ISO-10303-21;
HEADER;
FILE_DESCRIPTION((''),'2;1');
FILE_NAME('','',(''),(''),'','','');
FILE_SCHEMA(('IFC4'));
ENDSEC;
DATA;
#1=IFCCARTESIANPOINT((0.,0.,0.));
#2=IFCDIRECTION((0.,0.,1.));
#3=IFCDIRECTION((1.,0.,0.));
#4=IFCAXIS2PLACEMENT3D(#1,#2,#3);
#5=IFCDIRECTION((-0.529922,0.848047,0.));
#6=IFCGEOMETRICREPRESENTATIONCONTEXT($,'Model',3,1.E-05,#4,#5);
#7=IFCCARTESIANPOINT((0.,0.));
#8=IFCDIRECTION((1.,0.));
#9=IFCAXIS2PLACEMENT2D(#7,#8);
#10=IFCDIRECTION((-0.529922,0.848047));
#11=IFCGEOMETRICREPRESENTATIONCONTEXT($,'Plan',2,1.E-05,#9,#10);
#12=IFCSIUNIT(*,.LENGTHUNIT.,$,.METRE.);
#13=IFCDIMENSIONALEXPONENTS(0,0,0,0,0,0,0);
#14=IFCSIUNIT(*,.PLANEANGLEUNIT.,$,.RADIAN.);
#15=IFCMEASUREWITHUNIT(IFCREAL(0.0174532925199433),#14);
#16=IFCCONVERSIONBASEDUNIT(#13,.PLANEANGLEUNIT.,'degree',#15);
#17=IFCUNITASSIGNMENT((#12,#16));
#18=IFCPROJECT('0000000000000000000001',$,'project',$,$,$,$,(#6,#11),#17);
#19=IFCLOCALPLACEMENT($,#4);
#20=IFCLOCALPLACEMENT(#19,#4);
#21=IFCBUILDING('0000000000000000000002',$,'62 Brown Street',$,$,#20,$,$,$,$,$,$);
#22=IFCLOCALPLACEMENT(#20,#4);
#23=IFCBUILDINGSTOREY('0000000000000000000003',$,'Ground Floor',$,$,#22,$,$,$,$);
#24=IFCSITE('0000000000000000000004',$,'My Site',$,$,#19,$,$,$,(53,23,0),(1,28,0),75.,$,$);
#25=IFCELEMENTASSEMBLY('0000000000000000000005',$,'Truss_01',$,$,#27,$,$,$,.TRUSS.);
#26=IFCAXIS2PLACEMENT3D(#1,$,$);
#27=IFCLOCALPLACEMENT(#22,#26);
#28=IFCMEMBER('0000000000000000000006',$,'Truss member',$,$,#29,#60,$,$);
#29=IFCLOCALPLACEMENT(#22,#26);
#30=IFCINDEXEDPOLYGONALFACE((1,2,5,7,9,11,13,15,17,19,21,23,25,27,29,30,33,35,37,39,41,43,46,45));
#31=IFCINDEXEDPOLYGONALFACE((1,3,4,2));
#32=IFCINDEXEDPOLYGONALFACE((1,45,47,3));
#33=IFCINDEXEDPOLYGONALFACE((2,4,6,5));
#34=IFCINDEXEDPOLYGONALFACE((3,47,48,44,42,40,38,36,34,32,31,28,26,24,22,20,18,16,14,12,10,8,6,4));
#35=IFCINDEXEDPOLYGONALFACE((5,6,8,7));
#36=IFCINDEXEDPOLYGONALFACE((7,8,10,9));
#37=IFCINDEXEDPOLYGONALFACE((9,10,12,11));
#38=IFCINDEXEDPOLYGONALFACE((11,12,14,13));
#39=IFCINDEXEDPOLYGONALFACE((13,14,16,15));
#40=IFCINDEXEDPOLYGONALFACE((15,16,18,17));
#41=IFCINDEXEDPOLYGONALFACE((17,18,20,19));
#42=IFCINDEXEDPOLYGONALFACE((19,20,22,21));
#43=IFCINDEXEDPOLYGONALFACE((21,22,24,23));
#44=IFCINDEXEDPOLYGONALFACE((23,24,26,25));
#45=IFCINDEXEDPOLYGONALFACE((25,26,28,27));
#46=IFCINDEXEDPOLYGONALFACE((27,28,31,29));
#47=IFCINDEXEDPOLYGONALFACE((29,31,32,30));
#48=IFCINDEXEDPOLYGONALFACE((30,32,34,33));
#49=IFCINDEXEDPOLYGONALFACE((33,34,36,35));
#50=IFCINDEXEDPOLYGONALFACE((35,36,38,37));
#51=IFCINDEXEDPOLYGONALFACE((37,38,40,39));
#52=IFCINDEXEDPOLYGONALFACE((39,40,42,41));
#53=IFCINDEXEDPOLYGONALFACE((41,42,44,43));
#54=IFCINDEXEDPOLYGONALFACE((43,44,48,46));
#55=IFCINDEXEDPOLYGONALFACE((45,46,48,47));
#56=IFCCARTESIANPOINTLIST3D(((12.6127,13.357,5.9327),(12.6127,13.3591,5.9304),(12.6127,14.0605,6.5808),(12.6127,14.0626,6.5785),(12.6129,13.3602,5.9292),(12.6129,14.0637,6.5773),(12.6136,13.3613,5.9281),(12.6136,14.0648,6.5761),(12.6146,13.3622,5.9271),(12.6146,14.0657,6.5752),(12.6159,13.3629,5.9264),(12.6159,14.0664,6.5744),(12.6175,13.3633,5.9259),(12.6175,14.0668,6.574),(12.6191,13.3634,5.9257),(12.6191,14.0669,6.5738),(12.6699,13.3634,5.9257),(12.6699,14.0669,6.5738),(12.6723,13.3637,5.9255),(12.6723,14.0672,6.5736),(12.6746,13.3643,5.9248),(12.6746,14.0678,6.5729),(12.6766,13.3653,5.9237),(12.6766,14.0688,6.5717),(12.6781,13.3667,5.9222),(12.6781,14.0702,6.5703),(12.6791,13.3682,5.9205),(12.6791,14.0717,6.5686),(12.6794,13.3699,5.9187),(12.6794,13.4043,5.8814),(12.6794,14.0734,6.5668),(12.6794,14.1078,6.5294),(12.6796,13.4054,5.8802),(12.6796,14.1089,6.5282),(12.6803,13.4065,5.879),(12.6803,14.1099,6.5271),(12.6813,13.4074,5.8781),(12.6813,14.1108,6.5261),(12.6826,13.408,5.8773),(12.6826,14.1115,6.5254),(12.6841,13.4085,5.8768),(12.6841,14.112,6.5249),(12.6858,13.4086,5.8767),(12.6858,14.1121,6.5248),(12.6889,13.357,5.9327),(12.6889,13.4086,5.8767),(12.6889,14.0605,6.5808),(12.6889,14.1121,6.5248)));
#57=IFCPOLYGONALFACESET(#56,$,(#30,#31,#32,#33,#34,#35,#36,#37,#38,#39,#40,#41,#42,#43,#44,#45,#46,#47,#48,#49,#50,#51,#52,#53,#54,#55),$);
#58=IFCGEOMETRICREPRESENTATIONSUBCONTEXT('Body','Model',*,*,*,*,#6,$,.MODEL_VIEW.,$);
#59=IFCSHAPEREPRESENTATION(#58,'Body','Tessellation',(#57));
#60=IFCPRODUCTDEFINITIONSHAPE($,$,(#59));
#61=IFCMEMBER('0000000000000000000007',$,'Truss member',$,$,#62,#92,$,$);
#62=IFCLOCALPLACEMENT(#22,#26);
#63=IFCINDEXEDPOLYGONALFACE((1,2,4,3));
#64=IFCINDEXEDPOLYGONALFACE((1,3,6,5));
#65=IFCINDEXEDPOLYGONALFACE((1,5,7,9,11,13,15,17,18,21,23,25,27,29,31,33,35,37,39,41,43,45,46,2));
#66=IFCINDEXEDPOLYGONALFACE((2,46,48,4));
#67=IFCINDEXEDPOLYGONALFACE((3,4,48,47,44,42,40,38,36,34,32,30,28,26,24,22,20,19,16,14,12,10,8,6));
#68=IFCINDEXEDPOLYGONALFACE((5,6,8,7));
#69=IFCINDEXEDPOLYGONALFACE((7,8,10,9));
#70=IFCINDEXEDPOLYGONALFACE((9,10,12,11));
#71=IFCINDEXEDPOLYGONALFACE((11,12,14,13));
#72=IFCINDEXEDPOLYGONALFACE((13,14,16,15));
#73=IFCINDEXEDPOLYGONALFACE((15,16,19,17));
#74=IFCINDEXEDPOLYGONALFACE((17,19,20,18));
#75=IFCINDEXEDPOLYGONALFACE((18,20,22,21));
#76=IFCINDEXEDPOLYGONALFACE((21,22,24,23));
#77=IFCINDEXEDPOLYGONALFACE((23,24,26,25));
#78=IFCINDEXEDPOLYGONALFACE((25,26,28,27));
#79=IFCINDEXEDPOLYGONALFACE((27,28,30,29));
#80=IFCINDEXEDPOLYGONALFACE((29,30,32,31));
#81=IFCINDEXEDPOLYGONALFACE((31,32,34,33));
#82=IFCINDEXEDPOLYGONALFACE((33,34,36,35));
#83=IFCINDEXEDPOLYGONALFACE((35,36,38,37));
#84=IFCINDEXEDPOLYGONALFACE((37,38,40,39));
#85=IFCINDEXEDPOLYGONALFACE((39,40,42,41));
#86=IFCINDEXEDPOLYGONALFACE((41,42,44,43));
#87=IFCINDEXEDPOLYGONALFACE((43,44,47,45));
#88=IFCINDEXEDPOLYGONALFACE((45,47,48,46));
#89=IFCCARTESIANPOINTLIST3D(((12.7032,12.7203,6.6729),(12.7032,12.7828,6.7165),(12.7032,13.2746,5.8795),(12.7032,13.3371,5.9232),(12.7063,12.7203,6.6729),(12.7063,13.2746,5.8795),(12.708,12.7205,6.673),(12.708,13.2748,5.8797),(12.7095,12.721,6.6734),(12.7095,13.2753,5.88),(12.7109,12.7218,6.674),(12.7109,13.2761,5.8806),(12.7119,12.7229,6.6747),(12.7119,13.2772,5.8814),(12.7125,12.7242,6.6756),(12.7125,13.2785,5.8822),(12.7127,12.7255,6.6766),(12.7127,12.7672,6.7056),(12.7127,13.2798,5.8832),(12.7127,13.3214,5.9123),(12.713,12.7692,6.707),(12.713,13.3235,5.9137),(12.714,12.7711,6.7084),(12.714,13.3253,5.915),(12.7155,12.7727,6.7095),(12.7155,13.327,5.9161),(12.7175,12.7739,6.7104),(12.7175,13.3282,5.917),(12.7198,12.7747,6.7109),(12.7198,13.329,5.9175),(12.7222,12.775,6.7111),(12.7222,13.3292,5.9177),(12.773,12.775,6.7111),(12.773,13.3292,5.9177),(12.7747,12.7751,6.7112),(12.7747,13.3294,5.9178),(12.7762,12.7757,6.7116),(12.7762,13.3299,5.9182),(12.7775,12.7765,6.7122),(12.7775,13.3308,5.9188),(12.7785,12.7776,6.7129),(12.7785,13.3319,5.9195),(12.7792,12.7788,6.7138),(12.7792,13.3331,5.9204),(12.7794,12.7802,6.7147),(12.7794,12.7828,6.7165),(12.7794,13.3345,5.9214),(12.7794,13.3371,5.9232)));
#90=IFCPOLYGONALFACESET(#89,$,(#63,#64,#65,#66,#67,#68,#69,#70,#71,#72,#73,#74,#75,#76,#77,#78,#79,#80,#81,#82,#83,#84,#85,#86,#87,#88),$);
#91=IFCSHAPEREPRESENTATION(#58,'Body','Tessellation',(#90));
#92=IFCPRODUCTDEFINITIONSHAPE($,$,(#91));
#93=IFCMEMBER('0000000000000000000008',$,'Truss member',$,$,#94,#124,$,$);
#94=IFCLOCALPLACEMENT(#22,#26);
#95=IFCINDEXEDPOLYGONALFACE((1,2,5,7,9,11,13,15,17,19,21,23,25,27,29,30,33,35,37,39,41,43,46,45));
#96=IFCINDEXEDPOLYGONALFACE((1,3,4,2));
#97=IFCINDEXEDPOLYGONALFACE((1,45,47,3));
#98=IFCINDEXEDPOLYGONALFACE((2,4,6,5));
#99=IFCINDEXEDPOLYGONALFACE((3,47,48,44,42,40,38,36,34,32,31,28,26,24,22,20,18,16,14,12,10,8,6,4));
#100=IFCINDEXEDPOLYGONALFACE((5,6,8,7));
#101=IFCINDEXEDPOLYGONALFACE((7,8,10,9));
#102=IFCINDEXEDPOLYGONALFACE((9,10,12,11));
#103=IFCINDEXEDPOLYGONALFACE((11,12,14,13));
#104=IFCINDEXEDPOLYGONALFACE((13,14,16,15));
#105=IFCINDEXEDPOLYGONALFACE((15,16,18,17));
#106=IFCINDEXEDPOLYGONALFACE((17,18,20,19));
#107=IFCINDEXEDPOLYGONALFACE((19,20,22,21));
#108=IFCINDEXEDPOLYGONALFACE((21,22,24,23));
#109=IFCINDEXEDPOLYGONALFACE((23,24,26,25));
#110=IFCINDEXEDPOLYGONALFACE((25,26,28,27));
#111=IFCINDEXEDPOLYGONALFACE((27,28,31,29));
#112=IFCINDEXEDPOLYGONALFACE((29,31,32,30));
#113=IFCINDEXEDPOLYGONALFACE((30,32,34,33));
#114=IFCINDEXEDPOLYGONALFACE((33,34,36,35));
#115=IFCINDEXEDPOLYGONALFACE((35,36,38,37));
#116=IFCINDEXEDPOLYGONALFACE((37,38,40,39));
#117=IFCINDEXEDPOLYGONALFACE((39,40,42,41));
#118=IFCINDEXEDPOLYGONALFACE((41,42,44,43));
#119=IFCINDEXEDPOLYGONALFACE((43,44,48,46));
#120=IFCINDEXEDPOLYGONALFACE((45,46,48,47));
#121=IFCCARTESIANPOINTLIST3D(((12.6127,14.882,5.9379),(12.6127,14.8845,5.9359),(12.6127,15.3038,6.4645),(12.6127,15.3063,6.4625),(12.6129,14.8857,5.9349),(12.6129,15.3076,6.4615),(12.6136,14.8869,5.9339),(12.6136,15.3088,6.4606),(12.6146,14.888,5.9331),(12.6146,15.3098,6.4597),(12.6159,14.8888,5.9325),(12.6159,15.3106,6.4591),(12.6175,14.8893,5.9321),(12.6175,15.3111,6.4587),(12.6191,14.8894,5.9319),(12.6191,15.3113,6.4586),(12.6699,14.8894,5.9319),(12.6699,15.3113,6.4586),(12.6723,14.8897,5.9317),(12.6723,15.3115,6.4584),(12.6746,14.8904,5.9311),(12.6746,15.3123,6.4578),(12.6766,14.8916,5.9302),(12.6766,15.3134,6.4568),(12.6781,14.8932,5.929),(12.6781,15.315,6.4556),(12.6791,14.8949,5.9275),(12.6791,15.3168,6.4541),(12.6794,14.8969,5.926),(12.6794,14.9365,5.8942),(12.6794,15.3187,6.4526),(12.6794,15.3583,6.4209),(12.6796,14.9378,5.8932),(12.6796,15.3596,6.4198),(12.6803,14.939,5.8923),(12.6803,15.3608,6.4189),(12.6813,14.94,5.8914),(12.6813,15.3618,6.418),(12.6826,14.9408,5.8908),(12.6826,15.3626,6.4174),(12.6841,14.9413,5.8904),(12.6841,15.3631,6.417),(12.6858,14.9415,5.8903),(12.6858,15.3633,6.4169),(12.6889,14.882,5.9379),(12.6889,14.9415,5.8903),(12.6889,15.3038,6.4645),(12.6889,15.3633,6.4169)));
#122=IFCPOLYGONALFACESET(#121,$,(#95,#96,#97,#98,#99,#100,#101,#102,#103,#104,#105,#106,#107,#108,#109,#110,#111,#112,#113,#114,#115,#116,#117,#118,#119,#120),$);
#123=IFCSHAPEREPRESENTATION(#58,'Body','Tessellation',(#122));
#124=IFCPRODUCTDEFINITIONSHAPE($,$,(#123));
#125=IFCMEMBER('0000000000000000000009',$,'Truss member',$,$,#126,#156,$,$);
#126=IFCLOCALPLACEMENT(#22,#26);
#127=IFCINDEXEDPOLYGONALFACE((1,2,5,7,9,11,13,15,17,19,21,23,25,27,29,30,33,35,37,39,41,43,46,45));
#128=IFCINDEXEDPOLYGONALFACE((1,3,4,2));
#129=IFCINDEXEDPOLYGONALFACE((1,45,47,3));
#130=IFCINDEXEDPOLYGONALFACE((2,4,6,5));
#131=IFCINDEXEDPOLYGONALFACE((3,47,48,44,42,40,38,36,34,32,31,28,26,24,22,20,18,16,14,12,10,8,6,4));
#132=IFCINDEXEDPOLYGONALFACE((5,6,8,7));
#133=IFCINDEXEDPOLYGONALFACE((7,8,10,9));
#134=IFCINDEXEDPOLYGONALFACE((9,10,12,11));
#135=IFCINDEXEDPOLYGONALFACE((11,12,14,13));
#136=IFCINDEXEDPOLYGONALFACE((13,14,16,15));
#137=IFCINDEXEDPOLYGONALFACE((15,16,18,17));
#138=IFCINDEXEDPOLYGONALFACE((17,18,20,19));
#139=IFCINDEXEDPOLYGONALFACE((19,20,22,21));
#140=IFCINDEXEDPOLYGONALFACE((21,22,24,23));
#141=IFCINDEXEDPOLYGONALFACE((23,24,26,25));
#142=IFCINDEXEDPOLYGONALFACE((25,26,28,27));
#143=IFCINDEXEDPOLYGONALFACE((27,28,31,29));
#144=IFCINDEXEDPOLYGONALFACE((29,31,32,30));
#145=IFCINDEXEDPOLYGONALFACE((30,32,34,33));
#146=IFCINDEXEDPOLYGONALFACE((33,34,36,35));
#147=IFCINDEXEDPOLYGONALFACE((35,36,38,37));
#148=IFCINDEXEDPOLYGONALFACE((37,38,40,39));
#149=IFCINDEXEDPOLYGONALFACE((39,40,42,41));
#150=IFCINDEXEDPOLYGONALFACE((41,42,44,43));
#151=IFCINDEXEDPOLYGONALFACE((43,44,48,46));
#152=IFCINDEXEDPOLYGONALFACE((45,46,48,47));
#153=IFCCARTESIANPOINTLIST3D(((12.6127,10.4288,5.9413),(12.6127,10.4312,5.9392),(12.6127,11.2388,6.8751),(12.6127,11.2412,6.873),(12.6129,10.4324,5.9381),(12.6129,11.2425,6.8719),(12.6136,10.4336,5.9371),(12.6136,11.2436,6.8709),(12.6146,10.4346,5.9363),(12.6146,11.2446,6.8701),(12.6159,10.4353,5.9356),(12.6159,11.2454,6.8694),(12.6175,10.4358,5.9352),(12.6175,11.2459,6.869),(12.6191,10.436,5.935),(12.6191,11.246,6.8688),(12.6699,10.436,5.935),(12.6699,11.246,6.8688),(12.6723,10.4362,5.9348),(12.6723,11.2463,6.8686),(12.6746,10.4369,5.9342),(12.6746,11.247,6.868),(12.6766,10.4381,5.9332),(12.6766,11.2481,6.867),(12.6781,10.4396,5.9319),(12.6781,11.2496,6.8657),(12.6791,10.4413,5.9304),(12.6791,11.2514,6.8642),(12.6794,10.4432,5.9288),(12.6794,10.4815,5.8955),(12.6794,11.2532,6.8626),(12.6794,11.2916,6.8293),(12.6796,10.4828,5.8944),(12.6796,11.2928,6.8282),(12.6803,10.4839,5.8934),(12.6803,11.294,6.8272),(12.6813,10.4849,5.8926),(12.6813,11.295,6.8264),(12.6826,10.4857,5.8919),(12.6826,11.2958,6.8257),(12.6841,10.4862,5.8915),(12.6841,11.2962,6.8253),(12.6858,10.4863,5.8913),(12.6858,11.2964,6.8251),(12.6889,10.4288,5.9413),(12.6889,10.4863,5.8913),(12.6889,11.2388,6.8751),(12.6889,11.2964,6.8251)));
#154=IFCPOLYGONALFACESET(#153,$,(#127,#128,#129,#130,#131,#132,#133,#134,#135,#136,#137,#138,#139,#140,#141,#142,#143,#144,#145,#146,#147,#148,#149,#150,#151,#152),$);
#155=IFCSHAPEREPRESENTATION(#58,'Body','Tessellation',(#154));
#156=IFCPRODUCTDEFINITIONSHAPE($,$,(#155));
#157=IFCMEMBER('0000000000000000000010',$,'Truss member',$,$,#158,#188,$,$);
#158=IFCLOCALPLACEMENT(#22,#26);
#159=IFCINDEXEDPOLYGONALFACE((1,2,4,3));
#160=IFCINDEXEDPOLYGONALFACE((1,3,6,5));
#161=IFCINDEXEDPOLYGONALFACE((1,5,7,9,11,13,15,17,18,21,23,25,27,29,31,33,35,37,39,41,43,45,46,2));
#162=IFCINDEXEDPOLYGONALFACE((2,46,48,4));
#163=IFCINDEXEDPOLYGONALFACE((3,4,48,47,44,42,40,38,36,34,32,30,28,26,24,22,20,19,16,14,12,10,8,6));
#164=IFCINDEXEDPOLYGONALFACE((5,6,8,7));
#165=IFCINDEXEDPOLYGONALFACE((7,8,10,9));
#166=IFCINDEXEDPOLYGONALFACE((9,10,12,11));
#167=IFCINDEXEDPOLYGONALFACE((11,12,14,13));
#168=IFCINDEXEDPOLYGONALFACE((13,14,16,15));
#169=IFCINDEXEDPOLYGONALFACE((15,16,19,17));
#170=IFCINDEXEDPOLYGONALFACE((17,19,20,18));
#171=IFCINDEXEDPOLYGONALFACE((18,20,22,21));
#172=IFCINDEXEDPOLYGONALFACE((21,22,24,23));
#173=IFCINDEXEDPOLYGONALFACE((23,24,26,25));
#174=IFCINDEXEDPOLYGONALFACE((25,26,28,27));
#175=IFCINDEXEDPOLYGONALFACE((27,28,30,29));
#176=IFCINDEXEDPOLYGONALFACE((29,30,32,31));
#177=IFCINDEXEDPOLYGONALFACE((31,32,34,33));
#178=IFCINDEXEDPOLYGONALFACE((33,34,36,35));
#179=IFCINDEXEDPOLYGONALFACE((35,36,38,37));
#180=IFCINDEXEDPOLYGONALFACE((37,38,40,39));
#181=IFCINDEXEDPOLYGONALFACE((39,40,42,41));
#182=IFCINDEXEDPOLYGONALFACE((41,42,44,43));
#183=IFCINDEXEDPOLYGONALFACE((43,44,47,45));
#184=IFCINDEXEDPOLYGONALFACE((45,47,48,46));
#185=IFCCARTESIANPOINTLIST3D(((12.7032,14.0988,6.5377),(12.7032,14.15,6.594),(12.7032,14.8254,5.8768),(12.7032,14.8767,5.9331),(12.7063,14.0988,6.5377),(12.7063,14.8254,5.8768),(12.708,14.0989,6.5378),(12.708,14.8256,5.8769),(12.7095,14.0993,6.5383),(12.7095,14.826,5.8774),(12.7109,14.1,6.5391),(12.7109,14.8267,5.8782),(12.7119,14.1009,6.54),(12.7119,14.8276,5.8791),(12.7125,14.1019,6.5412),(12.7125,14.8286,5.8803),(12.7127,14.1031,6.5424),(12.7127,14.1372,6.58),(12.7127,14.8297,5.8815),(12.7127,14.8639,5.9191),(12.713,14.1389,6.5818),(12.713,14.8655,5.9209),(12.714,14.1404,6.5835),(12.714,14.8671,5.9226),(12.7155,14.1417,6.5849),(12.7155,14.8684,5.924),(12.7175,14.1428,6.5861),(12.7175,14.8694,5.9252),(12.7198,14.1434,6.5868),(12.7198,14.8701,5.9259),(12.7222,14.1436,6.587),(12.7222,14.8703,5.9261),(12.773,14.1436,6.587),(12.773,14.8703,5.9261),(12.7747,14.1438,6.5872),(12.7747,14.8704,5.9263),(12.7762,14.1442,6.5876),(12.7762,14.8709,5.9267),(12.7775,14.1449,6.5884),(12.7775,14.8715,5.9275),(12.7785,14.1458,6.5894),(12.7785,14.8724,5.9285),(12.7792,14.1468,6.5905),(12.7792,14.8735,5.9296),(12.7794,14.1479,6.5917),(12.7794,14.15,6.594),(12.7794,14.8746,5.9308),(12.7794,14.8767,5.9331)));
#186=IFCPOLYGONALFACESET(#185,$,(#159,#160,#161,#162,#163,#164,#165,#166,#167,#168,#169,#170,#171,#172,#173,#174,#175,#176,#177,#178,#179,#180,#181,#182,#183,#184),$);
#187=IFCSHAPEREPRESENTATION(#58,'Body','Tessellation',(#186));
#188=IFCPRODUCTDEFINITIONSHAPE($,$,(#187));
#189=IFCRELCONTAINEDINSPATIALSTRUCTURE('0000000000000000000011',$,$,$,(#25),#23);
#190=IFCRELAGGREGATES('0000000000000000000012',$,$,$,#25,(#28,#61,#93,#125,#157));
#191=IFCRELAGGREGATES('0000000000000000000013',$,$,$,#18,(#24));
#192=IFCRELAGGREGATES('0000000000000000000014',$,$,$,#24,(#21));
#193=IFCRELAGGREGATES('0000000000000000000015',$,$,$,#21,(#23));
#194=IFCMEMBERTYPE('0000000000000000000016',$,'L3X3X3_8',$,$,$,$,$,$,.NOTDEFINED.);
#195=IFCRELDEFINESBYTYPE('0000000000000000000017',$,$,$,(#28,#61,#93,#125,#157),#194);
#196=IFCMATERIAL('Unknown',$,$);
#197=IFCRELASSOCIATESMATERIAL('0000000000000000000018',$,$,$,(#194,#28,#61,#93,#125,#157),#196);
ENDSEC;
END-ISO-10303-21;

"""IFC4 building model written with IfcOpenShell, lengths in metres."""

from ifc_helpers import new_model, entity, si_unit, converted_unit, direction, frame, origin_with_axes, origin_2d_with_axis, place, context, subcontext, project, spatial, l_section, extrude, material, material_profile, profile_set, profile_usage, type_object, element, aggregate, save


model = new_model("IFC4")

# Units and contexts
model_context = context("Model", 3, precision=1e-05, world=origin_with_axes(), true_north=direction((-0.529922, 0.848047, 0.0)))
plan_context = context("Plan", 2, precision=1e-05, world=origin_2d_with_axis(), true_north=direction((-0.529922, 0.848047)))
body_context = subcontext(model_context, "Body", "Model", "MODEL_VIEW")
ifc_project = project(units=[si_unit("LENGTHUNIT", "METRE"), converted_unit("PLANEANGLEUNIT", "degree", entity("IfcReal", 0.0174532925199433), si_unit("PLANEANGLEUNIT", "RADIAN"), dimensions=[0, 0, 0, 0, 0, 0, 0])], contexts=[model_context, plan_context])

# Site, building, storey
site_placement = place(None, origin_with_axes())
site = spatial("IfcSite", under=ifc_project, at=site_placement, Name="My Site", RefLatitude=(53, 23, 0), RefLongitude=(1, 28, 0), RefElevation=75.0)
building_placement = place(site_placement, origin_with_axes())
building = spatial("IfcBuilding", under=site, at=building_placement, Name="62 Brown Street")
storey_placement = place(building_placement, origin_with_axes())
storey = spatial("IfcBuildingStorey", under=building, at=storey_placement, Name="Ground Floor")

# Element assembly, members
ifc_material_1 = material(Name="Unknown")
ifc_material_profile_1 = material_profile(ifc_material_1, l_section(Depth=0.0762, Width=0.0762, Thickness=0.0095, FilletRadius=0.0095, EdgeRadius=0.0064))
ifc_profile_set_1 = profile_set([ifc_material_profile_1])
member_type_1 = type_object("IfcMemberType", Name="L3X3X3_8", PredefinedType="NOTDEFINED", material=ifc_profile_set_1)
assembly_1_placement = place(storey_placement, frame((12.7032, 10.4288, 6.9738), z_axis=(0.0, 0.0, 1.0), x_axis=(1.0, 0.0, 0.0)))
assembly_1 = element("IfcElementAssembly", 1, at=assembly_1_placement, inside=storey, Name="Truss_01", PredefinedType="TRUSS")
ifc_profile_usage_1 = profile_usage(ifc_profile_set_1, cardinal=5)
member_1_placement = place(assembly_1_placement, frame((-0.0524, 3.6575, -0.421), z_axis=(0.000001, -0.735484, -0.677542), x_axis=(-1.0, -0.000001, 0.0)))
member_1 = element("IfcMember", 2, at=member_1_placement, type_object=member_type_1, material=ifc_profile_usage_1, Name="Truss member", context=body_context, shape_type="SweptSolid", body=[
    extrude(l_section(Depth=0.0762, Width=0.0762, Thickness=0.0095, FilletRadius=0.0095, EdgeRadius=0.0064), origin_with_axes(), (0.0, 0.0, 1.0), 0.9565),
])
ifc_profile_usage_2 = profile_usage(ifc_profile_set_1, cardinal=5)
member_2_placement = place(assembly_1_placement, frame((0.0381, 2.3228, -0.279), z_axis=(-0.000001, 0.572709, -0.819759), x_axis=(1.0, 0.0, 0.0)))
member_2 = element("IfcMember", 3, at=member_2_placement, type_object=member_type_1, material=ifc_profile_usage_2, Name="Truss member", context=body_context, shape_type="SweptSolid", body=[
    extrude(l_section(Depth=0.0762, Width=0.0762, Thickness=0.0095, FilletRadius=0.0095, EdgeRadius=0.0064), origin_with_axes(), (0.0, 0.0, 1.0), 0.9678),
])
ifc_profile_usage_3 = profile_usage(ifc_profile_set_1, cardinal=5)
member_3_placement = place(assembly_1_placement, frame((-0.0524, 4.9048, -0.5331), z_axis=(0.000001, -0.625169, -0.780489), x_axis=(-1.0, -0.000001, 0.0)))
member_3 = element("IfcMember", 4, at=member_3_placement, type_object=member_type_1, material=ifc_profile_usage_3, Name="Truss member", context=body_context, shape_type="SweptSolid", body=[
    extrude(l_section(Depth=0.0762, Width=0.0762, Thickness=0.0095, FilletRadius=0.0095, EdgeRadius=0.0064), origin_with_axes(), (0.0, 0.0, 1.0), 0.6747),
])
ifc_profile_usage_4 = profile_usage(ifc_profile_set_1, cardinal=5)
member_4_placement = place(assembly_1_placement, frame((-0.0524, 0.8388, -0.1236), z_axis=(0.000001, -0.655276, -0.755389), x_axis=(-1.0, -0.000001, 0.0)))
member_4 = element("IfcMember", 5, at=member_4_placement, type_object=member_type_1, material=ifc_profile_usage_4, Name="Truss member", context=body_context, shape_type="SweptSolid", body=[
    extrude(l_section(Depth=0.0762, Width=0.0762, Thickness=0.0095, FilletRadius=0.0095, EdgeRadius=0.0064), origin_with_axes(), (0.0, 0.0, 1.0), 1.2362),
])
ifc_profile_usage_5 = profile_usage(ifc_profile_set_1, cardinal=5)
member_5_placement = place(assembly_1_placement, frame((0.0381, 3.6956, -0.4079), z_axis=(-0.000001, 0.739785, -0.672843), x_axis=(1.0, 0.000001, 0.0)))
member_5 = element("IfcMember", 6, at=member_5_placement, type_object=member_type_1, material=ifc_profile_usage_5, Name="Truss member", context=body_context, shape_type="SweptSolid", body=[
    extrude(l_section(Depth=0.0762, Width=0.0762, Thickness=0.0095, FilletRadius=0.0095, EdgeRadius=0.0064), origin_with_axes(), (0.0, 0.0, 1.0), 0.9823),
])

aggregate(assembly_1, [member_1, member_2, member_3, member_4, member_5])

save(model, "model.ifc")
